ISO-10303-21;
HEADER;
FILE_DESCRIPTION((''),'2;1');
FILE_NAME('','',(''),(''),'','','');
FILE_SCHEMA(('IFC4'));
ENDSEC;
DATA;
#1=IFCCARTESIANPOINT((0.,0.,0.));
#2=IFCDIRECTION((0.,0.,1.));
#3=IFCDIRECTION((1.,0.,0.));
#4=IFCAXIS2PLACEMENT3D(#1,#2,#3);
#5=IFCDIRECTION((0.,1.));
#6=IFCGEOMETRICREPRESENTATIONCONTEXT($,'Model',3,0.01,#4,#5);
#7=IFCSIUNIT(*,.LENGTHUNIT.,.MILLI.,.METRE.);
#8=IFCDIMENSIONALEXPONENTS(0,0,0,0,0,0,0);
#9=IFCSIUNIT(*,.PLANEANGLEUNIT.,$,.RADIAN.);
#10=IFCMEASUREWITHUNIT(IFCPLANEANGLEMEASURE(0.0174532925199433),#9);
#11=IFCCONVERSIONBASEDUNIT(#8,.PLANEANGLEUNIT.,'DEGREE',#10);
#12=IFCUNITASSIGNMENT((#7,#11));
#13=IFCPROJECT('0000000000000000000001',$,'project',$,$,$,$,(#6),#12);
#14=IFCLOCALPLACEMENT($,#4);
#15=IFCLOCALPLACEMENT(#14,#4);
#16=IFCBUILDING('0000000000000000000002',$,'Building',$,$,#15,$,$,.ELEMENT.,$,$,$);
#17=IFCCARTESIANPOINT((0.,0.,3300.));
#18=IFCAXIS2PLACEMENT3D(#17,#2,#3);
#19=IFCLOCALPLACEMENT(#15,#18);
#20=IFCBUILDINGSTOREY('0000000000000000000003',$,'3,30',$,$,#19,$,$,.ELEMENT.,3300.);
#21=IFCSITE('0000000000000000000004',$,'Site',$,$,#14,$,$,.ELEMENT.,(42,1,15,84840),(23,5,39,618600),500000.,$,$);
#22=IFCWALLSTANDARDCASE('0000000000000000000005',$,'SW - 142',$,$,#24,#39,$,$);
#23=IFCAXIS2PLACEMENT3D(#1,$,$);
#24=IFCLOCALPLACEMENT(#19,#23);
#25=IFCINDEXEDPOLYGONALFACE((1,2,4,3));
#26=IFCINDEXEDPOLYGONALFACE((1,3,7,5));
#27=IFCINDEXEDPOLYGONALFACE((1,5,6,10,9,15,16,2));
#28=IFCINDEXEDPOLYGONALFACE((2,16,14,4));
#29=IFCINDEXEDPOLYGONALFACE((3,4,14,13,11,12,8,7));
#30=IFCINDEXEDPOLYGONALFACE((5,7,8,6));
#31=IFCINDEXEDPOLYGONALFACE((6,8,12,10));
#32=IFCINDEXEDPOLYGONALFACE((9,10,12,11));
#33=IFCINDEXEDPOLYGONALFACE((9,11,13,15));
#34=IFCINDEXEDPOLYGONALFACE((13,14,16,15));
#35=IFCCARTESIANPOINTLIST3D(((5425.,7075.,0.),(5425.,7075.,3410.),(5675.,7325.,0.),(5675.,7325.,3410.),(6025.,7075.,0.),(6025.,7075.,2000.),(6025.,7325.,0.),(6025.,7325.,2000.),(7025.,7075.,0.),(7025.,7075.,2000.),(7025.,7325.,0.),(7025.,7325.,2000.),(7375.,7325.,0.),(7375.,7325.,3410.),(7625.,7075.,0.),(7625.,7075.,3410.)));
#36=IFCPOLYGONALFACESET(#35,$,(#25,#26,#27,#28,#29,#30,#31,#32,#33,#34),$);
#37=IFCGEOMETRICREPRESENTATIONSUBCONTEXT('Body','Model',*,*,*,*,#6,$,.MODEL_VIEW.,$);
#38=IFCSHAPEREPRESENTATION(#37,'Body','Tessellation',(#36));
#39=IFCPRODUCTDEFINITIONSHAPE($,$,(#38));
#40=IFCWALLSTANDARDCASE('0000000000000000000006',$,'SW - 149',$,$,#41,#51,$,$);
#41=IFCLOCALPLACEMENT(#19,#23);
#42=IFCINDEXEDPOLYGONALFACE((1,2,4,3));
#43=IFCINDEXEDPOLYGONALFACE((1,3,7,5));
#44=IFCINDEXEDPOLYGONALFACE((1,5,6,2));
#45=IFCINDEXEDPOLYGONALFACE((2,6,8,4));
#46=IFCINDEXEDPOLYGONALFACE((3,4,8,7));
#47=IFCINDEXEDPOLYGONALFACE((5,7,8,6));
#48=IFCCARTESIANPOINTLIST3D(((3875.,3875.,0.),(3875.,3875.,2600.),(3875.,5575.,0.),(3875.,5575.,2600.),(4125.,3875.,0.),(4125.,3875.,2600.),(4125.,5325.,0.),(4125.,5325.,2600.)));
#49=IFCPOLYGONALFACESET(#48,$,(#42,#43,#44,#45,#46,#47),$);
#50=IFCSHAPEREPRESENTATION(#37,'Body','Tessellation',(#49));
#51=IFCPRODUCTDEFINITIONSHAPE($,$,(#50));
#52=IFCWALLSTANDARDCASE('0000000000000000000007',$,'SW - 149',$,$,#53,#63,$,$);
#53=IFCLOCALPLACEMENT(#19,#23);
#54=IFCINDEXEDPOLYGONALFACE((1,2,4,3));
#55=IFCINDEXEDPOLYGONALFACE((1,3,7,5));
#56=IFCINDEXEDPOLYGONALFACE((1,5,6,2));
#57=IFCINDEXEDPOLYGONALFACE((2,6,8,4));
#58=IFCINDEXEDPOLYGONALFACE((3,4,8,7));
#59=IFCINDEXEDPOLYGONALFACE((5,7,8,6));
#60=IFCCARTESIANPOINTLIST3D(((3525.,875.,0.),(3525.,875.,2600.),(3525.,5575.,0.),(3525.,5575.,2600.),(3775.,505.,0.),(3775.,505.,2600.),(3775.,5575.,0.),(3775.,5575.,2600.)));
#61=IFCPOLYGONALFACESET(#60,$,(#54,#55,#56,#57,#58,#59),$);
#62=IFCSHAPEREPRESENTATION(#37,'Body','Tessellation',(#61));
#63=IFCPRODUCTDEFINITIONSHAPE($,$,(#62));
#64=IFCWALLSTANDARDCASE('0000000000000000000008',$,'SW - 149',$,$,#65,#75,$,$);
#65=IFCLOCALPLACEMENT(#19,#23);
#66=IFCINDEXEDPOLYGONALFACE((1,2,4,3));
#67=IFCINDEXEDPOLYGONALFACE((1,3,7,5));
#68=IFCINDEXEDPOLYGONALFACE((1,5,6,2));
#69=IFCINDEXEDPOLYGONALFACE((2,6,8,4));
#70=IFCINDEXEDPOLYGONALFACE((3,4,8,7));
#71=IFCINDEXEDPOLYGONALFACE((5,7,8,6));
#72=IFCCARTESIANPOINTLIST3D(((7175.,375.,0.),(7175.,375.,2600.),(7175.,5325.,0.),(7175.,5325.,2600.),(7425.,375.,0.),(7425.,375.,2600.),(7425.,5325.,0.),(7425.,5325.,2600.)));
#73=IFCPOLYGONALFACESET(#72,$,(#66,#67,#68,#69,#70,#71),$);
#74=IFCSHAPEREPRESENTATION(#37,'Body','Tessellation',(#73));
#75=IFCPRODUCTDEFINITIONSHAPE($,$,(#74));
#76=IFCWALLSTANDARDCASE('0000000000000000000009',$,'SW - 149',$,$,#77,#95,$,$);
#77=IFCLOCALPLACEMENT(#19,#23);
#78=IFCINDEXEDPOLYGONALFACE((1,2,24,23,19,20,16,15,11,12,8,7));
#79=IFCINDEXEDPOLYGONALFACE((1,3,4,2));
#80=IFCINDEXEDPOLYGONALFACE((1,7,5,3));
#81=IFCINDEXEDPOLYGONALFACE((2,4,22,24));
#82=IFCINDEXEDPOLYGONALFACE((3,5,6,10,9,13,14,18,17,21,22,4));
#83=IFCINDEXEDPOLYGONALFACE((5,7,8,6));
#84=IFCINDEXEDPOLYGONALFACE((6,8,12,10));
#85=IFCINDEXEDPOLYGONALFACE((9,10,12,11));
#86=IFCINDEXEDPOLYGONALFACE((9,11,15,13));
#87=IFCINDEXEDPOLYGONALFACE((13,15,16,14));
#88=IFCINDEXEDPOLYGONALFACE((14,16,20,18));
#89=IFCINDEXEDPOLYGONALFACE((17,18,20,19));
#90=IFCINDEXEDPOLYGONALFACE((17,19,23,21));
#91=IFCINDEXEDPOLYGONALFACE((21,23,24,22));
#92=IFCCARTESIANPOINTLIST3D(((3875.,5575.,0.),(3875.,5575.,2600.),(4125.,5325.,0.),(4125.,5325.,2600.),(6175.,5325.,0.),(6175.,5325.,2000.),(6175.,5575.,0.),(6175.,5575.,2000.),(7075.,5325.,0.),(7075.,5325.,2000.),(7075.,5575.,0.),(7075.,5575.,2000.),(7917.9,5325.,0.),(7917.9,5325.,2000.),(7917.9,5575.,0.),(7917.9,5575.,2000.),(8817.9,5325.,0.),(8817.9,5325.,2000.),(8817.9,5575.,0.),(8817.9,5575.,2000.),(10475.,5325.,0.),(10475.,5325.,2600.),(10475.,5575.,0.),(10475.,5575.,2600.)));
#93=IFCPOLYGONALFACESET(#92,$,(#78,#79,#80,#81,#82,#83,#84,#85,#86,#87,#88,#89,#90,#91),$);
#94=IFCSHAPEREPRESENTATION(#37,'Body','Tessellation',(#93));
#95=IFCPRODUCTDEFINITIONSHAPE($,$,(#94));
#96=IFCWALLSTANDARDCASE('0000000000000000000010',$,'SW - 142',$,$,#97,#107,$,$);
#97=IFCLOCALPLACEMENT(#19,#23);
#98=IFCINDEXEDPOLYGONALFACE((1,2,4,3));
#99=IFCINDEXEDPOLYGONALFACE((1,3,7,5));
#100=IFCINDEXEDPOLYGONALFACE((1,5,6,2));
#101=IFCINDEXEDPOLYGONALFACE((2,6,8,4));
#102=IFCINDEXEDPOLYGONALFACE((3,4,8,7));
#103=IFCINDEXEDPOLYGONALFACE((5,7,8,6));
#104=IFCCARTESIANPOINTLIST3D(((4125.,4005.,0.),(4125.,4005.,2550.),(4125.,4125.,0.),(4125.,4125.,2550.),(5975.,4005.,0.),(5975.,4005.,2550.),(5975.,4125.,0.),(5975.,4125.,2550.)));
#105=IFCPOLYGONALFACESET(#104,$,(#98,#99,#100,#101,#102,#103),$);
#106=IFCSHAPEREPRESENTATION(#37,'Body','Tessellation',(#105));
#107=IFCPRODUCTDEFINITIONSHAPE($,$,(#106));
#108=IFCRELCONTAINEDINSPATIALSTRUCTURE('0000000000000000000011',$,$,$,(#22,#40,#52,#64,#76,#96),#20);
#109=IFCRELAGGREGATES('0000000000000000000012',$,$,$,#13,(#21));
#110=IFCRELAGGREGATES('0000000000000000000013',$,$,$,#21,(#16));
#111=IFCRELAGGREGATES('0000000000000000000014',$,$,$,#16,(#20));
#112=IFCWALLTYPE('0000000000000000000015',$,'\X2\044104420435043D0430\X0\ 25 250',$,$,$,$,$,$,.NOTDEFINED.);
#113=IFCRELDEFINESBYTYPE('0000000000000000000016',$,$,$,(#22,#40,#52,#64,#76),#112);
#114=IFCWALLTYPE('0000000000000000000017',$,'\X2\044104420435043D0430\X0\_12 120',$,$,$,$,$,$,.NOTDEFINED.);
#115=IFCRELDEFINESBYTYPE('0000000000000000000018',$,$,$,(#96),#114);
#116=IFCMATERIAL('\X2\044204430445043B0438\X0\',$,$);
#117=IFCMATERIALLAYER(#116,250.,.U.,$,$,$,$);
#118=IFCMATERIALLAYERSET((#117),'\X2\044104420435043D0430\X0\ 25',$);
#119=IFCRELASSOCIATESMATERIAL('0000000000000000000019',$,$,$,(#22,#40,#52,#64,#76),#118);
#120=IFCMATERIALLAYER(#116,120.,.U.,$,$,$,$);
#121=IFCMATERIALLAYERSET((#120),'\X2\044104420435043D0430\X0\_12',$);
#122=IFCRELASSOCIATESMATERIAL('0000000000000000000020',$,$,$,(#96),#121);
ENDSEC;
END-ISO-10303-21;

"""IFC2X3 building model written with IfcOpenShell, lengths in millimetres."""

from ifc_helpers import new_model, entity, si_unit, converted_unit, direction, frame, origin_with_axes, origin_2d_with_axis, place, context, subcontext, project, spatial, polyline, rectangle, outline, extrude, material, layer, layer_set, layer_usage, type_object, element, save


model = new_model("IFC2X3")

# Units and contexts
model_context = context("Model", 3, precision=0.01, world=origin_with_axes(), true_north=direction((0.0, 1.0)))
body_context = subcontext(model_context, "Body", "Model", "MODEL_VIEW")
ifc_project = project(units=[si_unit("LENGTHUNIT", "METRE", prefix="MILLI"), converted_unit("PLANEANGLEUNIT", "DEGREE", entity("IfcPlaneAngleMeasure", 0.0174532925199433), si_unit("PLANEANGLEUNIT", "RADIAN"), dimensions=[0, 0, 0, 0, 0, 0, 0])], contexts=[model_context])

# Site, building, storey
site_placement = place(None, origin_with_axes())
site = spatial("IfcSite", under=ifc_project, at=site_placement, Name="Site", CompositionType="ELEMENT", RefLatitude=(42, 1, 15, 84840), RefLongitude=(23, 5, 39, 618600), RefElevation=500000.0)
building_placement = place(site_placement, origin_with_axes())
building = spatial("IfcBuilding", under=site, at=building_placement, Name="Building", CompositionType="ELEMENT")
storey_placement = place(building_placement, frame((0.0, 0.0, 3300.0), z_axis=(0.0, 0.0, 1.0), x_axis=(1.0, 0.0, 0.0)))
storey = spatial("IfcBuildingStorey", under=building, at=storey_placement, Name="3,30", CompositionType="ELEMENT", Elevation=3300.0)

# Shared definitions
ifc_material_1 = material(Name="тухли")

# Wall, opening
ifc_layer_1 = layer(ifc_material_1, 250.0, ventilated="UNKNOWN")
ifc_layer_set_1 = layer_set([ifc_layer_1], Name="стена 25")
ifc_layer_usage_1 = layer_usage(ifc_layer_set_1, "AXIS2", "NEGATIVE", 0.0)
wall_type_1 = type_object("IfcWallType", Name="стена 25 250", PredefinedType="NOTDEFINED")
wall_1_placement = place(storey_placement, frame((7625.0, 7075.0, 0.0), z_axis=(0.0, 0.0, 1.0), x_axis=(-1.0, 0.0, 0.0)))
wall_1 = element("IfcWallStandardCase", 1, at=wall_1_placement, inside=storey, type_object=wall_type_1, material=ifc_layer_usage_1, Name="SW - 142", context=body_context, shape_type="SweptSolid", body=[
    extrude(outline(polyline([(250.0, -250.0), (1950.0, -250.0), (2200.0, 0.0), (0.0, 0.0), (250.0, -250.0)])), origin_with_axes(), (0.0, 0.0, 1.0), 3410.0),
])
opening_1_placement = place(wall_1_placement, frame((1100.0, 0.0, 0.0), z_axis=(0.0, 0.0, 1.0), x_axis=(1.0, 0.0, 0.0)))
element("IfcOpeningElement", 2, at=opening_1_placement, cuts=wall_1, context=body_context, shape_type="SweptSolid", body=[
    extrude(rectangle(XDim=1000.0, YDim=2000.0, at=origin_2d_with_axis()), frame((0.0, -250.0, 1000.0), z_axis=(0.0, 1.0, 0.0), x_axis=(-1.0, 0.0, 0.0)), (0.0, 0.0, 1.0), 750.0),
])

# Walls
ifc_layer_usage_2 = layer_usage(ifc_layer_set_1, "AXIS2", "POSITIVE", 0.0)
wall_2_placement = place(storey_placement, frame((3875.0, 5575.0, 0.0), z_axis=(0.0, 0.0, 1.0), x_axis=(0.0, -1.0, 0.0)))
element("IfcWallStandardCase", 3, at=wall_2_placement, inside=storey, type_object=wall_type_1, material=ifc_layer_usage_2, Name="SW - 149", context=body_context, shape_type="SweptSolid", body=[
    extrude(outline(polyline([(0.0, 0.0), (1700.0, 0.0), (1700.0, 250.0), (250.0, 250.0), (0.0, 0.0)])), origin_with_axes(), (0.0, 0.0, 1.0), 2600.0),
])
ifc_layer_usage_3 = layer_usage(ifc_layer_set_1, "AXIS2", "POSITIVE", 0.0)
wall_3_placement = place(storey_placement, frame((3525.0, 5575.0, 0.0), z_axis=(0.0, 0.0, 1.0), x_axis=(0.0, -1.0, 0.0)))
element("IfcWallStandardCase", 4, at=wall_3_placement, inside=storey, type_object=wall_type_1, material=ifc_layer_usage_3, Name="SW - 149", context=body_context, shape_type="SweptSolid", body=[
    extrude(outline(polyline([(0.0, 0.0), (4700.0, 0.0), (5070.0, 250.0), (0.0, 250.0), (0.0, 0.0)])), origin_with_axes(), (0.0, 0.0, 1.0), 2600.0),
])
ifc_layer_usage_4 = layer_usage(ifc_layer_set_1, "AXIS2", "NEGATIVE", 0.0)
wall_4_placement = place(storey_placement, frame((7175.0, 125.0, 0.0), z_axis=(0.0, 0.0, 1.0), x_axis=(0.0, 1.0, 0.0)))
element("IfcWallStandardCase", 5, at=wall_4_placement, inside=storey, type_object=wall_type_1, material=ifc_layer_usage_4, Name="SW - 149", context=body_context, shape_type="SweptSolid", body=[
    extrude(outline(polyline([(250.0, -250.0), (5200.0, -250.0), (5200.0, 0.0), (250.0, 0.0), (250.0, -250.0)])), origin_with_axes(), (0.0, 0.0, 1.0), 2600.0),
])

# Wall, openings
ifc_layer_usage_5 = layer_usage(ifc_layer_set_1, "AXIS2", "NEGATIVE", 0.0)
wall_5_placement = place(storey_placement, frame((3875.0, 5575.0, 0.0), z_axis=(0.0, 0.0, 1.0), x_axis=(1.0, 0.0, 0.0)))
wall_5 = element("IfcWallStandardCase", 6, at=wall_5_placement, inside=storey, type_object=wall_type_1, material=ifc_layer_usage_5, Name="SW - 149", context=body_context, shape_type="SweptSolid", body=[
    extrude(outline(polyline([(250.0, -250.0), (6600.0, -250.0), (6600.0, 0.0), (0.0, 0.0), (250.0, -250.0)])), origin_with_axes(), (0.0, 0.0, 1.0), 2600.0),
])
opening_2_placement = place(wall_5_placement, frame((4492.9, 0.0, 0.0), z_axis=(0.0, 0.0, 1.0), x_axis=(1.0, 0.0, 0.0)))
element("IfcOpeningElement", 7, at=opening_2_placement, cuts=wall_5, context=body_context, shape_type="SweptSolid", body=[
    extrude(rectangle(XDim=900.0, YDim=2000.0, at=origin_2d_with_axis()), frame((0.0, 250.0, 1000.0), z_axis=(0.0, -1.0, 0.0), x_axis=(-1.0, 0.0, 0.0)), (0.0, 0.0, 1.0), 750.0),
])
opening_3_placement = place(wall_5_placement, frame((2750.0, 0.0, 0.0), z_axis=(0.0, 0.0, 1.0), x_axis=(1.0, 0.0, 0.0)))
element("IfcOpeningElement", 8, at=opening_3_placement, cuts=wall_5, context=body_context, shape_type="SweptSolid", body=[
    extrude(rectangle(XDim=900.0, YDim=2000.0, at=origin_2d_with_axis()), frame((0.0, 250.0, 1000.0), z_axis=(0.0, 1.0, 0.0), x_axis=(1.0, 0.0, 0.0)), (0.0, 0.0, -1.0), 750.0),
])

# Shared definitions
ifc_layer_2 = layer(ifc_material_1, 120.0, ventilated="UNKNOWN")
ifc_layer_set_2 = layer_set([ifc_layer_2], Name="стена_12")
wall_type_2 = type_object("IfcWallType", Name="стена_12 120", PredefinedType="NOTDEFINED")

# Wall
ifc_layer_usage_6 = layer_usage(ifc_layer_set_2, "AXIS2", "NEGATIVE", 60.0)
wall_6_placement = place(storey_placement, frame((4125.0, 4065.0, 0.0), z_axis=(0.0, 0.0, 1.0), x_axis=(1.0, 0.0, 0.0)))
element("IfcWallStandardCase", 9, at=wall_6_placement, inside=storey, type_object=wall_type_2, material=ifc_layer_usage_6, Name="SW - 142", context=body_context, shape_type="SweptSolid", body=[
    extrude(outline(polyline([(0.0, -60.0), (1850.0, -60.0), (1850.0, 60.0), (0.0, 60.0), (0.0, -60.0)])), origin_with_axes(), (0.0, 0.0, 1.0), 2550.0),
])

save(model, "model.ifc")
